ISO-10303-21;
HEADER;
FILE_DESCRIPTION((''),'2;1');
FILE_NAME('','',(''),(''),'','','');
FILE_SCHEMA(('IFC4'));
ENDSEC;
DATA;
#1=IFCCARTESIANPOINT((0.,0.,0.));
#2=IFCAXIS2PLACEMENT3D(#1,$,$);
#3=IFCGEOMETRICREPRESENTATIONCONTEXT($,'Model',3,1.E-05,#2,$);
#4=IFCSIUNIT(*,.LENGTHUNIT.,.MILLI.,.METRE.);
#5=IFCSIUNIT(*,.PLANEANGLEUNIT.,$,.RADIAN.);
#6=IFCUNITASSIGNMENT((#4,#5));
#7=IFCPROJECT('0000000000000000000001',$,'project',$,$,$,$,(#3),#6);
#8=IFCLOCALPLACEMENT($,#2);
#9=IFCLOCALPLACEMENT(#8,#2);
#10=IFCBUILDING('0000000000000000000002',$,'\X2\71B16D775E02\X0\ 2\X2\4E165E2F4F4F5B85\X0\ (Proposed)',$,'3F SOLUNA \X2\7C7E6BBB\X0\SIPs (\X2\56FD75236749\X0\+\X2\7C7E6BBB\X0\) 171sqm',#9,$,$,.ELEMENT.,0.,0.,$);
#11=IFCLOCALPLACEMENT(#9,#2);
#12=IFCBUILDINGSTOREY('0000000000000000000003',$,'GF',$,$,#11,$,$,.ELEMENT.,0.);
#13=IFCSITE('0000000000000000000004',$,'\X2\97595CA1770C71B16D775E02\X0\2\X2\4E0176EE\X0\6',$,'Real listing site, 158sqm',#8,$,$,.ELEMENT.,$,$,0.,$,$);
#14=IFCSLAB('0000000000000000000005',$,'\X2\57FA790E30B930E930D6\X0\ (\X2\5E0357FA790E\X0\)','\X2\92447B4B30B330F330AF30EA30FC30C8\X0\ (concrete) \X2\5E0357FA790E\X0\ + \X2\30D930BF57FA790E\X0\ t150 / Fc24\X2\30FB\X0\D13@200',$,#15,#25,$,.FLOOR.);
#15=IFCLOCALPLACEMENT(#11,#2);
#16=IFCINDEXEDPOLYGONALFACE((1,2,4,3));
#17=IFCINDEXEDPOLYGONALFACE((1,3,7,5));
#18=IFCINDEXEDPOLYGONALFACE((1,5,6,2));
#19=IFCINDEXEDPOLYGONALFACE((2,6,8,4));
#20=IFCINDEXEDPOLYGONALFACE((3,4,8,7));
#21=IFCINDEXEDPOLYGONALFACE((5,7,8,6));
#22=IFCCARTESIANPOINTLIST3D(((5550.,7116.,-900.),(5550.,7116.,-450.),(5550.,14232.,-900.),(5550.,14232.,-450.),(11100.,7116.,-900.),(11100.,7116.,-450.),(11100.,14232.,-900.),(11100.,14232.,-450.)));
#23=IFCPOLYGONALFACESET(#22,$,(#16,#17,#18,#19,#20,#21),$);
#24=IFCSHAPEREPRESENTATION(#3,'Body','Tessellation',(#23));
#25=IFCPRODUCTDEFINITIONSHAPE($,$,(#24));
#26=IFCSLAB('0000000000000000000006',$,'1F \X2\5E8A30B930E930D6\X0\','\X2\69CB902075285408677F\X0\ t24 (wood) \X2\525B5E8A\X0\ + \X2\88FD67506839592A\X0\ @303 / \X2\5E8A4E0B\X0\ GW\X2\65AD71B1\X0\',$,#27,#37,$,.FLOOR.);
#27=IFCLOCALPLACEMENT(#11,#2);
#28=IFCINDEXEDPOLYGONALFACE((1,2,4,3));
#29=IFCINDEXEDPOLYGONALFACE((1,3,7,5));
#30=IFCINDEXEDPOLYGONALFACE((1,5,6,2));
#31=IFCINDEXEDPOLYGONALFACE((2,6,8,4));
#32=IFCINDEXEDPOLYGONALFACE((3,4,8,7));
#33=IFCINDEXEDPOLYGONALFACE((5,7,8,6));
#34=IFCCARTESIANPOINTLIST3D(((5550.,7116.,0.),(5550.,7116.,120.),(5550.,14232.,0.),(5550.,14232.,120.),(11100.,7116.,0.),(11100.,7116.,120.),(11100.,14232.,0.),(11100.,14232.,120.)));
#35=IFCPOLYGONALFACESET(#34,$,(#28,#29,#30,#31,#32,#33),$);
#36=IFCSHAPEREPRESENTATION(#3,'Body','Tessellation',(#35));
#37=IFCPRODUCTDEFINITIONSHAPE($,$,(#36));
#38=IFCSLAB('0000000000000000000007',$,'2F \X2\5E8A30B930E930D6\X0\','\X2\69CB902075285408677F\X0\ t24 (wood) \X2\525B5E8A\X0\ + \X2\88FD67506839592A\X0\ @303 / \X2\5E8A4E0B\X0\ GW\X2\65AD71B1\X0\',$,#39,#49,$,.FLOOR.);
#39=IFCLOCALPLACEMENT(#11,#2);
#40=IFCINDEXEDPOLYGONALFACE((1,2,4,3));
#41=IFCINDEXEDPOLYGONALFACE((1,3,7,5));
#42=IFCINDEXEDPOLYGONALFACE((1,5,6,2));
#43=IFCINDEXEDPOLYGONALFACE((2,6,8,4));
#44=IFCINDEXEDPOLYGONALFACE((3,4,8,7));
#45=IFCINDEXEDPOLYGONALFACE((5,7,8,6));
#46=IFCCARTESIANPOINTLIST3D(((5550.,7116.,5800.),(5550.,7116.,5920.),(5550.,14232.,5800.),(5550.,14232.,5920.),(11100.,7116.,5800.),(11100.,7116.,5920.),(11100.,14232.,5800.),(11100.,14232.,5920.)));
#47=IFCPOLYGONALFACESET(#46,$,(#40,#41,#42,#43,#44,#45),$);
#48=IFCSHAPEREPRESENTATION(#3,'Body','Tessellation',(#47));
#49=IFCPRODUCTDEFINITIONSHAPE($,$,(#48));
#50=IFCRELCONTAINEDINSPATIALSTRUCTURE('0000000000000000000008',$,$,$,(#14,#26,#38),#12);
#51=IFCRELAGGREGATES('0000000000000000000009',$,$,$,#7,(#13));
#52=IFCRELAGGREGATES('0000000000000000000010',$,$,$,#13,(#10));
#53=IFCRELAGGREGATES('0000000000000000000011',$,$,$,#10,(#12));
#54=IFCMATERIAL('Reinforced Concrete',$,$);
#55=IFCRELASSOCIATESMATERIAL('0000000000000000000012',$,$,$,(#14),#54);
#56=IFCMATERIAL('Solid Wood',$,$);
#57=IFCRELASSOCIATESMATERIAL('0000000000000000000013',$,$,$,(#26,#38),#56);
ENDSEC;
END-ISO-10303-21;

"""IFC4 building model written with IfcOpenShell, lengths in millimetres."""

from ifc_helpers import new_model, si_unit, frame, frame_2d, origin, place, context, project, spatial, rectangle, extrude, material, element, save


model = new_model("IFC4")

# Units and contexts
model_context = context("Model", 3, precision=1e-05, world=origin())
ifc_project = project(units=[si_unit("LENGTHUNIT", "METRE", prefix="MILLI"), si_unit("PLANEANGLEUNIT", "RADIAN")], contexts=[model_context])

# Site, building, storey
site_placement = place(None, origin())
site = spatial("IfcSite", under=ifc_project, at=site_placement, Name="静岡県熱海市2丁目6", ObjectType="Real listing site, 158sqm", CompositionType="ELEMENT", RefElevation=0.0)
building_placement = place(site_placement, origin())
building = spatial("IfcBuilding", under=site, at=building_placement, Name="熱海市 2世帯住宅 (Proposed)", ObjectType="3F SOLUNA 籾殻SIPs (国産杉+籾殻) 171sqm", CompositionType="ELEMENT", ElevationOfRefHeight=0.0, ElevationOfTerrain=0.0)
storey_placement = place(building_placement, origin())
storey = spatial("IfcBuildingStorey", under=building, at=storey_placement, Name="GF", CompositionType="ELEMENT", Elevation=0.0)

# Slabs
ifc_material_1 = material(Name="Reinforced Concrete")
slab_1_placement = place(storey_placement, frame((2775.0, 3558.0, -450.0)))
element("IfcSlab", 1, at=slab_1_placement, inside=storey, material=ifc_material_1, Name="基礎スラブ (布基礎)", Description="鉄筋コンクリート (concrete) 布基礎 + ベタ基礎 t150 / Fc24・D13@200", PredefinedType="FLOOR", context=model_context, shape_type="SweptSolid", body=[
    extrude(rectangle(XDim=5550.0, YDim=7116.0, at=frame_2d((2775.0, 3558.0))), frame((2775.0, 3558.0, -450.0)), (0.0, 0.0, 1.0), 450.0),
])
ifc_material_2 = material(Name="Solid Wood")
slab_2_placement = place(storey_placement, frame((2775.0, 3558.0, 0.0)))
element("IfcSlab", 2, at=slab_2_placement, inside=storey, material=ifc_material_2, Name="1F 床スラブ", Description="構造用合板 t24 (wood) 剛床 + 製材根太 @303 / 床下 GW断熱", PredefinedType="FLOOR", context=model_context, shape_type="SweptSolid", body=[
    extrude(rectangle(XDim=5550.0, YDim=7116.0, at=frame_2d((2775.0, 3558.0))), frame((2775.0, 3558.0, 0.0)), (0.0, 0.0, 1.0), 120.0),
])
slab_3_placement = place(storey_placement, frame((2775.0, 3558.0, 2900.0)))
element("IfcSlab", 3, at=slab_3_placement, inside=storey, material=ifc_material_2, Name="2F 床スラブ", Description="構造用合板 t24 (wood) 剛床 + 製材根太 @303 / 床下 GW断熱", PredefinedType="FLOOR", context=model_context, shape_type="SweptSolid", body=[
    extrude(rectangle(XDim=5550.0, YDim=7116.0, at=frame_2d((2775.0, 3558.0))), frame((2775.0, 3558.0, 2900.0)), (0.0, 0.0, 1.0), 120.0),
])

save(model, "model.ifc")
